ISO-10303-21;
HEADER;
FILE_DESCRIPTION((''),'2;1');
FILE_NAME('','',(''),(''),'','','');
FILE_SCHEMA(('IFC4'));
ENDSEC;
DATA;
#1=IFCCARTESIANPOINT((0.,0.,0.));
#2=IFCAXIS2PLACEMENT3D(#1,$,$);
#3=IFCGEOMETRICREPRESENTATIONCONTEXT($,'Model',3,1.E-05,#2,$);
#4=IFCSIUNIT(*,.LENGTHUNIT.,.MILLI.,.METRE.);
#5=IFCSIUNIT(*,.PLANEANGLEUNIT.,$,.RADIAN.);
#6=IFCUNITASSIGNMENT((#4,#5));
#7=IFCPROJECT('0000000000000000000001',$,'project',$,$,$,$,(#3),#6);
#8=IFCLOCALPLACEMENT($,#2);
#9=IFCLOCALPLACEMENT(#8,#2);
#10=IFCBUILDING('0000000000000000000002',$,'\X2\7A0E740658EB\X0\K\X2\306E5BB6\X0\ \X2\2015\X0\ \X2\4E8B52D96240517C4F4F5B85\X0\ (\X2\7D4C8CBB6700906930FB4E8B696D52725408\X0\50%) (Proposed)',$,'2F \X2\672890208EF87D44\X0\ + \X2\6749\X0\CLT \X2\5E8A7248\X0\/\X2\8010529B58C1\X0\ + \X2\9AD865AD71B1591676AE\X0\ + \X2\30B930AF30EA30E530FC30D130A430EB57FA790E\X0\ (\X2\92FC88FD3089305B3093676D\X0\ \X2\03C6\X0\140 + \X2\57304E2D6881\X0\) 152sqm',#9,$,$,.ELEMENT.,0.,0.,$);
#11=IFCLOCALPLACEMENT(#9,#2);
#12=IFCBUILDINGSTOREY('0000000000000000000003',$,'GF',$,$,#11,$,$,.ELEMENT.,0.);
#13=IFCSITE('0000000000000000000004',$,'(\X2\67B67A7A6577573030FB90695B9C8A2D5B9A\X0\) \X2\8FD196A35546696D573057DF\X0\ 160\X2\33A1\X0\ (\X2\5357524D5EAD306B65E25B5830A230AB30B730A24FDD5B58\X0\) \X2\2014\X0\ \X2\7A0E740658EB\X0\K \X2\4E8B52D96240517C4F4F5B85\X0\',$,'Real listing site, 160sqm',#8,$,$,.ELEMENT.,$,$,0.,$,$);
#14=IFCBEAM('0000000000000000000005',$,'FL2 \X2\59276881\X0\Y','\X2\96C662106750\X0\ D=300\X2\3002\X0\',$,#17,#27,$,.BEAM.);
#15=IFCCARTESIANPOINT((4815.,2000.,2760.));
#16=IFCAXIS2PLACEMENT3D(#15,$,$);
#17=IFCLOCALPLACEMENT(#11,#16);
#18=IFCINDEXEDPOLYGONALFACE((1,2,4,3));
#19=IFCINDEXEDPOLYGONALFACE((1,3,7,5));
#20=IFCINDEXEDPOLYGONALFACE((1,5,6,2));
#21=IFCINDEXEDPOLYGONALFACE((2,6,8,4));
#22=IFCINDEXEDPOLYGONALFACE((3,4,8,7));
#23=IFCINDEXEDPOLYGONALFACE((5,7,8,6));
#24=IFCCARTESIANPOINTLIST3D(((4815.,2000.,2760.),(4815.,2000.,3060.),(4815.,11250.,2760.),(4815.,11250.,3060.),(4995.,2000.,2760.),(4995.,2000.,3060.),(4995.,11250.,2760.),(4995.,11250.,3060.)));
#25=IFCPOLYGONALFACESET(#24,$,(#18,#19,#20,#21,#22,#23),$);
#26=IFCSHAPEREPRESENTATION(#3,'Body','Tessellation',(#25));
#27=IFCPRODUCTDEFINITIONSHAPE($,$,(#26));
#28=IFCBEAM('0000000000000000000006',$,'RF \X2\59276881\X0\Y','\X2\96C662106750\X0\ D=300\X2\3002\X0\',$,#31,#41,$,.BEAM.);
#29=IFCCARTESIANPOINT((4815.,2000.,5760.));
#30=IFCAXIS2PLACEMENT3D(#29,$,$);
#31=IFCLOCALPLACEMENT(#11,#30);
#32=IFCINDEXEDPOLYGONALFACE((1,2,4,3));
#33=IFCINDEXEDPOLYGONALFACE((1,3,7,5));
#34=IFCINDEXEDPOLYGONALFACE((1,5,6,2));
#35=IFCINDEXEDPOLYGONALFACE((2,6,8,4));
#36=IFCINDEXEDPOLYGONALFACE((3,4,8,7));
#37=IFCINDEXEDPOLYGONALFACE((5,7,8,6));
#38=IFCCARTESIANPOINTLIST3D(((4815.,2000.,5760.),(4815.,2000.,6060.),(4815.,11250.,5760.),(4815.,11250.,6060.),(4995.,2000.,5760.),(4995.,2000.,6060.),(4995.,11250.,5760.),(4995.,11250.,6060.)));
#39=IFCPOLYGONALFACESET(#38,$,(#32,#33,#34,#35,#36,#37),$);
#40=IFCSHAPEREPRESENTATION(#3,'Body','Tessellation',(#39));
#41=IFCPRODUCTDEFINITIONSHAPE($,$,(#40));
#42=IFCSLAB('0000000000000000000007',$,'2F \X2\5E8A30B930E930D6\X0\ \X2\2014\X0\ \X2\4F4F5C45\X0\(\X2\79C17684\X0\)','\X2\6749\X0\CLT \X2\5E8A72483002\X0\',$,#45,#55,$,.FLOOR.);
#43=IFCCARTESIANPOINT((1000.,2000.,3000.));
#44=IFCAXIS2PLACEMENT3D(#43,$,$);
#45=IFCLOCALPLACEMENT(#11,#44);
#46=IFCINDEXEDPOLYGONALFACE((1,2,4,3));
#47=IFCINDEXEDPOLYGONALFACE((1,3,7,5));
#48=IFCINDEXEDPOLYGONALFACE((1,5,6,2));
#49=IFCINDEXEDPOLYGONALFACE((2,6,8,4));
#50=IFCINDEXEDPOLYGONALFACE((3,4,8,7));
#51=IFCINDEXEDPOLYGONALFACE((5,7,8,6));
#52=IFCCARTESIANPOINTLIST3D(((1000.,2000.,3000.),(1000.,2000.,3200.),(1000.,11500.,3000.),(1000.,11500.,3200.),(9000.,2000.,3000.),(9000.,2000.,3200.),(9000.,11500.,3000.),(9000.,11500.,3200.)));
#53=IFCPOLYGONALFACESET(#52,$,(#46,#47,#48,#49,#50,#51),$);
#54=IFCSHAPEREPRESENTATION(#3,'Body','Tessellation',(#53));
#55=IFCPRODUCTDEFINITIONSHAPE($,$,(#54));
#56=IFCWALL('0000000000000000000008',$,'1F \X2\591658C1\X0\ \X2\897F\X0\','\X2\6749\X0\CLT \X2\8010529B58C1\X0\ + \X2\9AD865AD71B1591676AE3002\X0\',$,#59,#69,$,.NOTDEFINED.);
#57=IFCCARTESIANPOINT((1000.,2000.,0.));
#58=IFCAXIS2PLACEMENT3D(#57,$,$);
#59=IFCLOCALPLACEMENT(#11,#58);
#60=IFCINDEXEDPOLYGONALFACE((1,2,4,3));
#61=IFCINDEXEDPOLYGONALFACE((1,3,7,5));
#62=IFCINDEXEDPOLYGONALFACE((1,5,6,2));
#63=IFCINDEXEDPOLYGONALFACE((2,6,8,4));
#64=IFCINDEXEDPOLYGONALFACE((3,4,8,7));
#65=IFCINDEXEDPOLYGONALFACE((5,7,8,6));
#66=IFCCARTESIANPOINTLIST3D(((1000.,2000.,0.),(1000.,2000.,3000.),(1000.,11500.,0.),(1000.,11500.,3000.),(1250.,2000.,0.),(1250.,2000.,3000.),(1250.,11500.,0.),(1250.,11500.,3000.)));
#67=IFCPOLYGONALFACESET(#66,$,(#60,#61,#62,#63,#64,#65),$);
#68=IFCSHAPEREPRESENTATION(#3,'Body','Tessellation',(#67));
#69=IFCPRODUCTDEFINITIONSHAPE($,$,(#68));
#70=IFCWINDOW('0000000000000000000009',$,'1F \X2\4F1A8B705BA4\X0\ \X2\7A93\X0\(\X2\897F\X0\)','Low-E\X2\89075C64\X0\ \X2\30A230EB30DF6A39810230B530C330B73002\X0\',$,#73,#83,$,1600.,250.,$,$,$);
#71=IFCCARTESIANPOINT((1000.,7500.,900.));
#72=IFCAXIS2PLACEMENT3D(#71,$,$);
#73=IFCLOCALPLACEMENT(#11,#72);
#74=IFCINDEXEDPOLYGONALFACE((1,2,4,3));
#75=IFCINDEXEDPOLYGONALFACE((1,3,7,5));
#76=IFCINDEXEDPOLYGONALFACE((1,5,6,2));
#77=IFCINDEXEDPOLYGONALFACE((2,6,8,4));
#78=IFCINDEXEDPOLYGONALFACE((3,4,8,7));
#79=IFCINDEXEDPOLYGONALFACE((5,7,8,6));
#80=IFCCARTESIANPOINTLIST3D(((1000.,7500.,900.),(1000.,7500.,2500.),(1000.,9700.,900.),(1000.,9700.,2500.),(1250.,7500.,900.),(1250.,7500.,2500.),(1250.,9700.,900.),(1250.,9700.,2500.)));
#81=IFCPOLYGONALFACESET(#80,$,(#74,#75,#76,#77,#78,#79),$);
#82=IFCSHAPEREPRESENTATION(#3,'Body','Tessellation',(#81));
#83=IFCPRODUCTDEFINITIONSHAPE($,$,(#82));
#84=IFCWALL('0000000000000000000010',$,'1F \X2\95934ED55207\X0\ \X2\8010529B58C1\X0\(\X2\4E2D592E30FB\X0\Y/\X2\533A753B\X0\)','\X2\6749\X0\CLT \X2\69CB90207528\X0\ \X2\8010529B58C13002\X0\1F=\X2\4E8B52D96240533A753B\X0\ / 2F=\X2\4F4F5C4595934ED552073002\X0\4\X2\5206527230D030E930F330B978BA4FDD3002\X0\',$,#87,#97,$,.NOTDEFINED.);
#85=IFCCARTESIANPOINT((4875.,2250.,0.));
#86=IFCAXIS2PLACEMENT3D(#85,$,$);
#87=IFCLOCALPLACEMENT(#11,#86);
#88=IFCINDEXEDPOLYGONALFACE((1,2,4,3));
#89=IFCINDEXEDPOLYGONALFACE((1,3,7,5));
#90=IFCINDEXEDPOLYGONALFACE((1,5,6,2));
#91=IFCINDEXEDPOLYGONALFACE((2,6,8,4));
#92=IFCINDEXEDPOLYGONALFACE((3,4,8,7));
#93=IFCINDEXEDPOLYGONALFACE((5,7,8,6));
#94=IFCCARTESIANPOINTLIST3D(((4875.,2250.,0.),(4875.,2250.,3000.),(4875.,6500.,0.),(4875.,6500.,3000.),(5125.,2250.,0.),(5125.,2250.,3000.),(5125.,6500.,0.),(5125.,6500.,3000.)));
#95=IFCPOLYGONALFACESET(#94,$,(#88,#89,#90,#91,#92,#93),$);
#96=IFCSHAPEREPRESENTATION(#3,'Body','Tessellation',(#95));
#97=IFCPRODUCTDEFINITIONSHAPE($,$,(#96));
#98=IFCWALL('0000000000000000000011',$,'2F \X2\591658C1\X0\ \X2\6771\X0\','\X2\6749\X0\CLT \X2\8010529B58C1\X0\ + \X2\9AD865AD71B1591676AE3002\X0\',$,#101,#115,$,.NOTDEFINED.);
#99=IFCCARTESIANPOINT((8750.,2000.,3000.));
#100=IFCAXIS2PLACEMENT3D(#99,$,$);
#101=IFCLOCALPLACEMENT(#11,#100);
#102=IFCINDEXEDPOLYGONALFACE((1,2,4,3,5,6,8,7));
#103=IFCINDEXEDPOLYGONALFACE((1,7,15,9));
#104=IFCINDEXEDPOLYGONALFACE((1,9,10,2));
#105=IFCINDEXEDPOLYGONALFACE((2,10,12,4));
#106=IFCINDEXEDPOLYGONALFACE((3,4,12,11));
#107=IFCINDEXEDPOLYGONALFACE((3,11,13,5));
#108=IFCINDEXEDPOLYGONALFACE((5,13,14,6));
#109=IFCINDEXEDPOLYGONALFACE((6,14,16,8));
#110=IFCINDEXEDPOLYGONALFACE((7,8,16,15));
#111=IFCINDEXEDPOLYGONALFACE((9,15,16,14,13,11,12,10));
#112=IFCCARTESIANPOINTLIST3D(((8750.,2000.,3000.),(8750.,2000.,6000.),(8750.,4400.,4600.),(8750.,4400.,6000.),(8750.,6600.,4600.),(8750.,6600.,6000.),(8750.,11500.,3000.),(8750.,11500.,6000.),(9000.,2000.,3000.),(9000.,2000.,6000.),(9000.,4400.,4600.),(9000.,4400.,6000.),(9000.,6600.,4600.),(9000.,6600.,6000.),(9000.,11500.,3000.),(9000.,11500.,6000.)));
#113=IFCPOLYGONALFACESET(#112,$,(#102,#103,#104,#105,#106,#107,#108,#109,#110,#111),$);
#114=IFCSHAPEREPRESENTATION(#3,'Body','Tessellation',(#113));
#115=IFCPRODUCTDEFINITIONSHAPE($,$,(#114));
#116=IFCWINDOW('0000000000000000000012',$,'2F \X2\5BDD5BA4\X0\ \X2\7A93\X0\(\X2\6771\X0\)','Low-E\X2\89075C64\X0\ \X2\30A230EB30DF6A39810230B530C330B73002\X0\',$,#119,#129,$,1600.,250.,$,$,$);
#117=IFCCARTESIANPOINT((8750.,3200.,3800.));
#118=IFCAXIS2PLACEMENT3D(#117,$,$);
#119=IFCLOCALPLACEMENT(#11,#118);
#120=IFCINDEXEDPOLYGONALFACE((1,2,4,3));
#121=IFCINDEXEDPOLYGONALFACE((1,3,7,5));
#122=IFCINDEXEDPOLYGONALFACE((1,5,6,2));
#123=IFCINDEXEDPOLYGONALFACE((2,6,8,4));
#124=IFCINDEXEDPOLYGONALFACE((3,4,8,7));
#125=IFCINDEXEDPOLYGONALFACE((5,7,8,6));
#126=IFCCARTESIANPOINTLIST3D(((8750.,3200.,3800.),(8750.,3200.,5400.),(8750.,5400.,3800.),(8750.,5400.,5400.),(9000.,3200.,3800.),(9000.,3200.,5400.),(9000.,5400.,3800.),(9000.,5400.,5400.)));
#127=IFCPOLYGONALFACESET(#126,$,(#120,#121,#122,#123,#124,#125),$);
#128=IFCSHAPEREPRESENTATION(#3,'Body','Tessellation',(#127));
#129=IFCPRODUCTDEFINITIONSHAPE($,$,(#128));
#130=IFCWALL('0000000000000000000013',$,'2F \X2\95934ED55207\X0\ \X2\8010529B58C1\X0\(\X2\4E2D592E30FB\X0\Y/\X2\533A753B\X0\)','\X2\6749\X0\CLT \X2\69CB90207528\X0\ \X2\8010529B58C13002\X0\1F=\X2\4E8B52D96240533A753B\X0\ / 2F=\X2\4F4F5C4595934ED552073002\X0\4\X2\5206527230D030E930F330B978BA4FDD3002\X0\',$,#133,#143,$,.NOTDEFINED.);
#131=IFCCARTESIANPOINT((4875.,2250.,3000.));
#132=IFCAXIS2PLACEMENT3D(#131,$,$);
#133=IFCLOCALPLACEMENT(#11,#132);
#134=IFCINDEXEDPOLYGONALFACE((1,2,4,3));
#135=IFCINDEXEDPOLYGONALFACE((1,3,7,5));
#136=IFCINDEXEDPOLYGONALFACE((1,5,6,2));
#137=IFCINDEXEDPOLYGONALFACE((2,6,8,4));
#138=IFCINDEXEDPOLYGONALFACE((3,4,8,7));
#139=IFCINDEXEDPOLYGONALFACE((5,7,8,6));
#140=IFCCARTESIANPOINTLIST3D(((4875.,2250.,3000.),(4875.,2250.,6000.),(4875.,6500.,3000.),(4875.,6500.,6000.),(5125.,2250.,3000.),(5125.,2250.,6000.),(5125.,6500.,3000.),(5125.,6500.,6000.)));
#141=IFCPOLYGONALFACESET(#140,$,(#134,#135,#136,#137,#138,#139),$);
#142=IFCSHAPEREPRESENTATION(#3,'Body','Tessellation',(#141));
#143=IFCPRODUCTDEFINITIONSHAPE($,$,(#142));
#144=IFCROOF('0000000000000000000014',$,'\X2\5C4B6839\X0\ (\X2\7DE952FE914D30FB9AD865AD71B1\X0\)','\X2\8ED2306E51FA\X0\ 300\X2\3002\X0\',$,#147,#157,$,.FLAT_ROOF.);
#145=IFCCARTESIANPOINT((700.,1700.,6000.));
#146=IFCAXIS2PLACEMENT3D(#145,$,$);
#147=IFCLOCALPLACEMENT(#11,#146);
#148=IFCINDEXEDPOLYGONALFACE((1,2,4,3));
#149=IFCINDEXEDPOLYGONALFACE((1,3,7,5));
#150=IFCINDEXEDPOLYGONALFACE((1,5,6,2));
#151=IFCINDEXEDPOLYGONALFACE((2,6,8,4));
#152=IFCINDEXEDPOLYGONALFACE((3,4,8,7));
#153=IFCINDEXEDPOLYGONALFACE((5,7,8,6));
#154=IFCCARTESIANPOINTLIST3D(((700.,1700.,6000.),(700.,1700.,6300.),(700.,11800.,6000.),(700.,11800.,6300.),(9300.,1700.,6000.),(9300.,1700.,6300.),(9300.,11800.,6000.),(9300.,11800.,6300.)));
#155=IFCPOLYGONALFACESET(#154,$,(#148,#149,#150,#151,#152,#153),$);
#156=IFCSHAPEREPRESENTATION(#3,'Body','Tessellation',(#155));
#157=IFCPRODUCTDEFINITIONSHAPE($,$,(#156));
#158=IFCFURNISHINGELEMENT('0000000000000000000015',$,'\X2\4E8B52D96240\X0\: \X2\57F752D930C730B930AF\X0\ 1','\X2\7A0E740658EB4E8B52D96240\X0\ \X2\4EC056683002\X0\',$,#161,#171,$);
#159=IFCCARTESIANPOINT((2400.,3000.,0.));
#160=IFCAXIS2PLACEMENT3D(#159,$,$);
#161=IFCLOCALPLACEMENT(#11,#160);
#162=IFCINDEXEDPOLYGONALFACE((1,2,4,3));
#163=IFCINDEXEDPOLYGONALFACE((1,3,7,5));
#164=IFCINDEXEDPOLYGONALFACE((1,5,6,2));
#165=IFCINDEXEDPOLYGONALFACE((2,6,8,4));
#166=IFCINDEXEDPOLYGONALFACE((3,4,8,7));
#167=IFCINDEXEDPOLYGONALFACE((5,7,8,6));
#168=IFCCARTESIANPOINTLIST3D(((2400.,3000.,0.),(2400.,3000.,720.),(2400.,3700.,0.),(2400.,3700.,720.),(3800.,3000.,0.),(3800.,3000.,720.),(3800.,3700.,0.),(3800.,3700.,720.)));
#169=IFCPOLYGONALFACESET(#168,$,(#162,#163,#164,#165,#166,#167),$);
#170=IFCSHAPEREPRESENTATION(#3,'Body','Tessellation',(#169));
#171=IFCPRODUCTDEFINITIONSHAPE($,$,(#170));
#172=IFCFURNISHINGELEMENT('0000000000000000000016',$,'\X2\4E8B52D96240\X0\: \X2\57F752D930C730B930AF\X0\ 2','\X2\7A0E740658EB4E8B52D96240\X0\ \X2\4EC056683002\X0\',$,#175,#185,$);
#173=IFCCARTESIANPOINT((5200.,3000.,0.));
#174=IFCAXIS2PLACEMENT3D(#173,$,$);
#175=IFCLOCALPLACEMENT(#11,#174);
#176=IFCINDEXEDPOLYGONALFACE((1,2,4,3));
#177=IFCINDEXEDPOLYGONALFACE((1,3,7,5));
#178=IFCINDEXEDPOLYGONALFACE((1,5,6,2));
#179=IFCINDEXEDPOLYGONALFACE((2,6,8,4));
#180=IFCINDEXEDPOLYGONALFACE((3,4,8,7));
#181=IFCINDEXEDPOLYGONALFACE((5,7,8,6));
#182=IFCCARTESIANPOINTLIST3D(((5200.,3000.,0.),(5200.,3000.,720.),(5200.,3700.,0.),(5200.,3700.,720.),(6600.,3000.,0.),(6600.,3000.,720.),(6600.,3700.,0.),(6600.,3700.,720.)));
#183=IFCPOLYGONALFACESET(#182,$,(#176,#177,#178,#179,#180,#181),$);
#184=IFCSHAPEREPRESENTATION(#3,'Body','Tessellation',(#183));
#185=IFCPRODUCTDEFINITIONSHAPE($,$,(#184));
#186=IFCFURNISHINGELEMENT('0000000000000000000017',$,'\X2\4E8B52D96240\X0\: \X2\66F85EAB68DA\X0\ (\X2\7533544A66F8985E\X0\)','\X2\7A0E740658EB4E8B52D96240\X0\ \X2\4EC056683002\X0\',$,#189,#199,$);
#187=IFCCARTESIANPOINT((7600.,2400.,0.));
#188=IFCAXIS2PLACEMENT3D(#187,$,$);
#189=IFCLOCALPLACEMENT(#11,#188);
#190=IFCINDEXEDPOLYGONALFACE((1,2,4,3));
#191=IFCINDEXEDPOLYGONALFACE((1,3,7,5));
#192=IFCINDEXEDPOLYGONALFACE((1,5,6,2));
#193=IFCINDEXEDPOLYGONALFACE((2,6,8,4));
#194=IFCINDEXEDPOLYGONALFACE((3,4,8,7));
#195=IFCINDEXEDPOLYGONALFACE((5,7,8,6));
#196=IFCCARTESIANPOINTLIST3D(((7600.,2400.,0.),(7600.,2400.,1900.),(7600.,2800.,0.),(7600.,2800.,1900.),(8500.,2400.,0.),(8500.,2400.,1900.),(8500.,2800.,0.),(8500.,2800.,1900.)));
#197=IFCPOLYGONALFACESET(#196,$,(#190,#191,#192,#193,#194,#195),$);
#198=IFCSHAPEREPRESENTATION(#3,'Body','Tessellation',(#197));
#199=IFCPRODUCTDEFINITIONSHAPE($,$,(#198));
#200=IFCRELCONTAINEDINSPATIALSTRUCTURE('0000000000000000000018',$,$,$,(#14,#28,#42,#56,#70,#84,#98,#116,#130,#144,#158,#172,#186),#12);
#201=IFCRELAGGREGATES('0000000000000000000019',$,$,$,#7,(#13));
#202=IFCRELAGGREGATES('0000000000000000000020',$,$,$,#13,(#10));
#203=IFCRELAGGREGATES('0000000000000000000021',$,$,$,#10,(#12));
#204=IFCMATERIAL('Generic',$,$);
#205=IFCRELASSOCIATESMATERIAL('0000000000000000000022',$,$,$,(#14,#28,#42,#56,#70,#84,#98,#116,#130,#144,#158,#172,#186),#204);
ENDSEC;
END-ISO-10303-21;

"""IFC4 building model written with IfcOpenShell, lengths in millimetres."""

from ifc_helpers import new_model, si_unit, frame, frame_2d, origin, place, context, project, spatial, rectangle, extrude, material, element, fill, save


model = new_model("IFC4")

# Units and contexts
model_context = context("Model", 3, precision=1e-05, world=origin())
ifc_project = project(units=[si_unit("LENGTHUNIT", "METRE", prefix="MILLI"), si_unit("PLANEANGLEUNIT", "RADIAN")], contexts=[model_context])

# Site, building, storey
site_placement = place(None, origin())
site = spatial("IfcSite", under=ifc_project, at=site_placement, Name="(架空敷地・適宜設定) 近隣商業地域 160㎡ (南前庭に既存アカシア保存) — 税理士K 事務所兼住宅", ObjectType="Real listing site, 160sqm", CompositionType="ELEMENT", RefElevation=0.0)
building_placement = place(site_placement, origin())
building = spatial("IfcBuilding", under=site, at=building_placement, Name="税理士Kの家 ― 事務所兼住宅 (経費最適・事業割合50%) (Proposed)", ObjectType="2F 木造軸組 + 杉CLT 床版/耐力壁 + 高断熱外皮 + スクリューパイル基礎 (鋼製らせん杭 φ140 + 地中梁) 152sqm", CompositionType="ELEMENT", ElevationOfRefHeight=0.0, ElevationOfTerrain=0.0)
storey_placement = place(building_placement, origin())
storey = spatial("IfcBuildingStorey", under=building, at=storey_placement, Name="GF", CompositionType="ELEMENT", Elevation=0.0)

# Beams
ifc_material = material(Name="Generic")
beam_1_placement = place(storey_placement, frame((4815.0, 2000.0, 2760.0)))
element("IfcBeam", 1, at=beam_1_placement, inside=storey, material=ifc_material, Name="FL2 大梁Y", Description="集成材 D=300。", PredefinedType="BEAM", context=model_context, shape_type="SweptSolid", body=[
    extrude(rectangle(XDim=180.0, YDim=9250.0, at=frame_2d((90.0, 4625.0))), frame((4815.0, 2000.0, 2760.0)), (0.0, 0.0, 1.0), 300.0),
])
beam_2_placement = place(storey_placement, frame((4815.0, 2000.0, 5760.0)))
element("IfcBeam", 2, at=beam_2_placement, inside=storey, material=ifc_material, Name="RF 大梁Y", Description="集成材 D=300。", PredefinedType="BEAM", context=model_context, shape_type="SweptSolid", body=[
    extrude(rectangle(XDim=180.0, YDim=9250.0, at=frame_2d((90.0, 4625.0))), frame((4815.0, 2000.0, 5760.0)), (0.0, 0.0, 1.0), 300.0),
])

# Slab
slab_1_placement = place(storey_placement, frame((1000.0, 2000.0, 3000.0)))
element("IfcSlab", 3, at=slab_1_placement, inside=storey, material=ifc_material, Name="2F 床スラブ — 住居(私的)", Description="杉CLT 床版。", PredefinedType="FLOOR", context=model_context, shape_type="SweptSolid", body=[
    extrude(rectangle(XDim=8000.0, YDim=9500.0, at=frame_2d((4000.0, 4750.0))), frame((1000.0, 2000.0, 3000.0)), (0.0, 0.0, 1.0), 200.0),
])

# Wall, opening, window
wall_1_placement = place(storey_placement, frame((1000.0, 2000.0, 0.0)))
wall_1 = element("IfcWall", 4, at=wall_1_placement, inside=storey, material=ifc_material, Name="1F 外壁 西", Description="杉CLT 耐力壁 + 高断熱外皮。", PredefinedType="NOTDEFINED", context=model_context, shape_type="SweptSolid", body=[
    extrude(rectangle(XDim=250.0, YDim=9500.0, at=frame_2d((125.0, 4750.0))), frame((1000.0, 2000.0, 0.0)), (0.0, 0.0, 1.0), 3000.0),
])
opening_1_placement = place(storey_placement, frame((1000.0, 7500.0, 900.0)))
opening_1 = element("IfcOpeningElement", 5, at=opening_1_placement, cuts=wall_1, PredefinedType="NOTDEFINED", context=model_context, shape_type="SweptSolid", body=[
    extrude(rectangle(XDim=250.0, YDim=2200.0, at=frame_2d((125.0, 1100.0))), frame((1000.0, 7500.0, 900.0)), (0.0, 0.0, 1.0), 1600.0),
])
window_1_placement = place(storey_placement, frame((1000.0, 7500.0, 900.0)))
window_1 = element("IfcWindow", 6, at=window_1_placement, inside=storey, material=ifc_material, Name="1F 会議室 窓(西)", Description="Low-E複層 アルミ樹脂サッシ。", OverallHeight=1600.0, OverallWidth=250.0, context=model_context, shape_type="SweptSolid", body=[
    extrude(rectangle(XDim=250.0, YDim=2200.0, at=frame_2d((125.0, 1100.0))), frame((1000.0, 7500.0, 900.0)), (0.0, 0.0, 1.0), 1600.0),
])
fill(opening_1, window_1)

# Wall
wall_2_placement = place(storey_placement, frame((4875.0, 2250.0, 0.0)))
element("IfcWall", 7, at=wall_2_placement, inside=storey, material=ifc_material, Name="1F 間仕切 耐力壁(中央・Y/区画)", Description="杉CLT 構造用 耐力壁。1F=事務所区画 / 2F=住居間仕切。4分割バランス確保。", PredefinedType="NOTDEFINED", context=model_context, shape_type="SweptSolid", body=[
    extrude(rectangle(XDim=250.0, YDim=4250.0, at=frame_2d((125.0, 2125.0))), frame((4875.0, 2250.0, 0.0)), (0.0, 0.0, 1.0), 3000.0),
])

# Wall, opening, window
wall_3_placement = place(storey_placement, frame((8750.0, 2000.0, 3000.0)))
wall_3 = element("IfcWall", 8, at=wall_3_placement, inside=storey, material=ifc_material, Name="2F 外壁 東", Description="杉CLT 耐力壁 + 高断熱外皮。", PredefinedType="NOTDEFINED", context=model_context, shape_type="SweptSolid", body=[
    extrude(rectangle(XDim=250.0, YDim=9500.0, at=frame_2d((125.0, 4750.0))), frame((8750.0, 2000.0, 3000.0)), (0.0, 0.0, 1.0), 3000.0),
])
opening_2_placement = place(storey_placement, frame((8750.0, 3200.0, 3800.0)))
opening_2 = element("IfcOpeningElement", 9, at=opening_2_placement, cuts=wall_3, PredefinedType="NOTDEFINED", context=model_context, shape_type="SweptSolid", body=[
    extrude(rectangle(XDim=250.0, YDim=2200.0, at=frame_2d((125.0, 1100.0))), frame((8750.0, 3200.0, 3800.0)), (0.0, 0.0, 1.0), 1600.0),
])
window_2_placement = place(storey_placement, frame((8750.0, 3200.0, 3800.0)))
window_2 = element("IfcWindow", 10, at=window_2_placement, inside=storey, material=ifc_material, Name="2F 寝室 窓(東)", Description="Low-E複層 アルミ樹脂サッシ。", OverallHeight=1600.0, OverallWidth=250.0, context=model_context, shape_type="SweptSolid", body=[
    extrude(rectangle(XDim=250.0, YDim=2200.0, at=frame_2d((125.0, 1100.0))), frame((8750.0, 3200.0, 3800.0)), (0.0, 0.0, 1.0), 1600.0),
])
fill(opening_2, window_2)

# Wall
wall_4_placement = place(storey_placement, frame((4875.0, 2250.0, 3000.0)))
element("IfcWall", 11, at=wall_4_placement, inside=storey, material=ifc_material, Name="2F 間仕切 耐力壁(中央・Y/区画)", Description="杉CLT 構造用 耐力壁。1F=事務所区画 / 2F=住居間仕切。4分割バランス確保。", PredefinedType="NOTDEFINED", context=model_context, shape_type="SweptSolid", body=[
    extrude(rectangle(XDim=250.0, YDim=4250.0, at=frame_2d((125.0, 2125.0))), frame((4875.0, 2250.0, 3000.0)), (0.0, 0.0, 1.0), 3000.0),
])

# Roof
roof_placement = place(storey_placement, frame((700.0, 1700.0, 6000.0)))
element("IfcRoof", 12, at=roof_placement, inside=storey, material=ifc_material, Name="屋根 (緩勾配・高断熱)", Description="軒の出 300。", PredefinedType="FLAT_ROOF", context=model_context, shape_type="SweptSolid", body=[
    extrude(rectangle(XDim=8600.0, YDim=10100.0, at=frame_2d((4300.0, 5050.0))), frame((700.0, 1700.0, 6000.0)), (0.0, 0.0, 1.0), 300.0),
])

# Furnishing elements
furnishing_1_placement = place(storey_placement, frame((2400.0, 3000.0, 0.0)))
element("IfcFurnishingElement", 13, at=furnishing_1_placement, inside=storey, material=ifc_material, Name="事務所: 執務デスク 1", Description="税理士事務所 什器。", context=model_context, shape_type="SweptSolid", body=[
    extrude(rectangle(XDim=1400.0, YDim=700.0, at=frame_2d((700.0, 350.0))), frame((2400.0, 3000.0, 0.0)), (0.0, 0.0, 1.0), 720.0),
])
furnishing_2_placement = place(storey_placement, frame((5200.0, 3000.0, 0.0)))
element("IfcFurnishingElement", 14, at=furnishing_2_placement, inside=storey, material=ifc_material, Name="事務所: 執務デスク 2", Description="税理士事務所 什器。", context=model_context, shape_type="SweptSolid", body=[
    extrude(rectangle(XDim=1400.0, YDim=700.0, at=frame_2d((700.0, 350.0))), frame((5200.0, 3000.0, 0.0)), (0.0, 0.0, 1.0), 720.0),
])
furnishing_3_placement = place(storey_placement, frame((7600.0, 2400.0, 0.0)))
element("IfcFurnishingElement", 15, at=furnishing_3_placement, inside=storey, material=ifc_material, Name="事務所: 書庫棚 (申告書類)", Description="税理士事務所 什器。", context=model_context, shape_type="SweptSolid", body=[
    extrude(rectangle(XDim=900.0, YDim=400.0, at=frame_2d((450.0, 200.0))), frame((7600.0, 2400.0, 0.0)), (0.0, 0.0, 1.0), 1900.0),
])

save(model, "model.ifc")
